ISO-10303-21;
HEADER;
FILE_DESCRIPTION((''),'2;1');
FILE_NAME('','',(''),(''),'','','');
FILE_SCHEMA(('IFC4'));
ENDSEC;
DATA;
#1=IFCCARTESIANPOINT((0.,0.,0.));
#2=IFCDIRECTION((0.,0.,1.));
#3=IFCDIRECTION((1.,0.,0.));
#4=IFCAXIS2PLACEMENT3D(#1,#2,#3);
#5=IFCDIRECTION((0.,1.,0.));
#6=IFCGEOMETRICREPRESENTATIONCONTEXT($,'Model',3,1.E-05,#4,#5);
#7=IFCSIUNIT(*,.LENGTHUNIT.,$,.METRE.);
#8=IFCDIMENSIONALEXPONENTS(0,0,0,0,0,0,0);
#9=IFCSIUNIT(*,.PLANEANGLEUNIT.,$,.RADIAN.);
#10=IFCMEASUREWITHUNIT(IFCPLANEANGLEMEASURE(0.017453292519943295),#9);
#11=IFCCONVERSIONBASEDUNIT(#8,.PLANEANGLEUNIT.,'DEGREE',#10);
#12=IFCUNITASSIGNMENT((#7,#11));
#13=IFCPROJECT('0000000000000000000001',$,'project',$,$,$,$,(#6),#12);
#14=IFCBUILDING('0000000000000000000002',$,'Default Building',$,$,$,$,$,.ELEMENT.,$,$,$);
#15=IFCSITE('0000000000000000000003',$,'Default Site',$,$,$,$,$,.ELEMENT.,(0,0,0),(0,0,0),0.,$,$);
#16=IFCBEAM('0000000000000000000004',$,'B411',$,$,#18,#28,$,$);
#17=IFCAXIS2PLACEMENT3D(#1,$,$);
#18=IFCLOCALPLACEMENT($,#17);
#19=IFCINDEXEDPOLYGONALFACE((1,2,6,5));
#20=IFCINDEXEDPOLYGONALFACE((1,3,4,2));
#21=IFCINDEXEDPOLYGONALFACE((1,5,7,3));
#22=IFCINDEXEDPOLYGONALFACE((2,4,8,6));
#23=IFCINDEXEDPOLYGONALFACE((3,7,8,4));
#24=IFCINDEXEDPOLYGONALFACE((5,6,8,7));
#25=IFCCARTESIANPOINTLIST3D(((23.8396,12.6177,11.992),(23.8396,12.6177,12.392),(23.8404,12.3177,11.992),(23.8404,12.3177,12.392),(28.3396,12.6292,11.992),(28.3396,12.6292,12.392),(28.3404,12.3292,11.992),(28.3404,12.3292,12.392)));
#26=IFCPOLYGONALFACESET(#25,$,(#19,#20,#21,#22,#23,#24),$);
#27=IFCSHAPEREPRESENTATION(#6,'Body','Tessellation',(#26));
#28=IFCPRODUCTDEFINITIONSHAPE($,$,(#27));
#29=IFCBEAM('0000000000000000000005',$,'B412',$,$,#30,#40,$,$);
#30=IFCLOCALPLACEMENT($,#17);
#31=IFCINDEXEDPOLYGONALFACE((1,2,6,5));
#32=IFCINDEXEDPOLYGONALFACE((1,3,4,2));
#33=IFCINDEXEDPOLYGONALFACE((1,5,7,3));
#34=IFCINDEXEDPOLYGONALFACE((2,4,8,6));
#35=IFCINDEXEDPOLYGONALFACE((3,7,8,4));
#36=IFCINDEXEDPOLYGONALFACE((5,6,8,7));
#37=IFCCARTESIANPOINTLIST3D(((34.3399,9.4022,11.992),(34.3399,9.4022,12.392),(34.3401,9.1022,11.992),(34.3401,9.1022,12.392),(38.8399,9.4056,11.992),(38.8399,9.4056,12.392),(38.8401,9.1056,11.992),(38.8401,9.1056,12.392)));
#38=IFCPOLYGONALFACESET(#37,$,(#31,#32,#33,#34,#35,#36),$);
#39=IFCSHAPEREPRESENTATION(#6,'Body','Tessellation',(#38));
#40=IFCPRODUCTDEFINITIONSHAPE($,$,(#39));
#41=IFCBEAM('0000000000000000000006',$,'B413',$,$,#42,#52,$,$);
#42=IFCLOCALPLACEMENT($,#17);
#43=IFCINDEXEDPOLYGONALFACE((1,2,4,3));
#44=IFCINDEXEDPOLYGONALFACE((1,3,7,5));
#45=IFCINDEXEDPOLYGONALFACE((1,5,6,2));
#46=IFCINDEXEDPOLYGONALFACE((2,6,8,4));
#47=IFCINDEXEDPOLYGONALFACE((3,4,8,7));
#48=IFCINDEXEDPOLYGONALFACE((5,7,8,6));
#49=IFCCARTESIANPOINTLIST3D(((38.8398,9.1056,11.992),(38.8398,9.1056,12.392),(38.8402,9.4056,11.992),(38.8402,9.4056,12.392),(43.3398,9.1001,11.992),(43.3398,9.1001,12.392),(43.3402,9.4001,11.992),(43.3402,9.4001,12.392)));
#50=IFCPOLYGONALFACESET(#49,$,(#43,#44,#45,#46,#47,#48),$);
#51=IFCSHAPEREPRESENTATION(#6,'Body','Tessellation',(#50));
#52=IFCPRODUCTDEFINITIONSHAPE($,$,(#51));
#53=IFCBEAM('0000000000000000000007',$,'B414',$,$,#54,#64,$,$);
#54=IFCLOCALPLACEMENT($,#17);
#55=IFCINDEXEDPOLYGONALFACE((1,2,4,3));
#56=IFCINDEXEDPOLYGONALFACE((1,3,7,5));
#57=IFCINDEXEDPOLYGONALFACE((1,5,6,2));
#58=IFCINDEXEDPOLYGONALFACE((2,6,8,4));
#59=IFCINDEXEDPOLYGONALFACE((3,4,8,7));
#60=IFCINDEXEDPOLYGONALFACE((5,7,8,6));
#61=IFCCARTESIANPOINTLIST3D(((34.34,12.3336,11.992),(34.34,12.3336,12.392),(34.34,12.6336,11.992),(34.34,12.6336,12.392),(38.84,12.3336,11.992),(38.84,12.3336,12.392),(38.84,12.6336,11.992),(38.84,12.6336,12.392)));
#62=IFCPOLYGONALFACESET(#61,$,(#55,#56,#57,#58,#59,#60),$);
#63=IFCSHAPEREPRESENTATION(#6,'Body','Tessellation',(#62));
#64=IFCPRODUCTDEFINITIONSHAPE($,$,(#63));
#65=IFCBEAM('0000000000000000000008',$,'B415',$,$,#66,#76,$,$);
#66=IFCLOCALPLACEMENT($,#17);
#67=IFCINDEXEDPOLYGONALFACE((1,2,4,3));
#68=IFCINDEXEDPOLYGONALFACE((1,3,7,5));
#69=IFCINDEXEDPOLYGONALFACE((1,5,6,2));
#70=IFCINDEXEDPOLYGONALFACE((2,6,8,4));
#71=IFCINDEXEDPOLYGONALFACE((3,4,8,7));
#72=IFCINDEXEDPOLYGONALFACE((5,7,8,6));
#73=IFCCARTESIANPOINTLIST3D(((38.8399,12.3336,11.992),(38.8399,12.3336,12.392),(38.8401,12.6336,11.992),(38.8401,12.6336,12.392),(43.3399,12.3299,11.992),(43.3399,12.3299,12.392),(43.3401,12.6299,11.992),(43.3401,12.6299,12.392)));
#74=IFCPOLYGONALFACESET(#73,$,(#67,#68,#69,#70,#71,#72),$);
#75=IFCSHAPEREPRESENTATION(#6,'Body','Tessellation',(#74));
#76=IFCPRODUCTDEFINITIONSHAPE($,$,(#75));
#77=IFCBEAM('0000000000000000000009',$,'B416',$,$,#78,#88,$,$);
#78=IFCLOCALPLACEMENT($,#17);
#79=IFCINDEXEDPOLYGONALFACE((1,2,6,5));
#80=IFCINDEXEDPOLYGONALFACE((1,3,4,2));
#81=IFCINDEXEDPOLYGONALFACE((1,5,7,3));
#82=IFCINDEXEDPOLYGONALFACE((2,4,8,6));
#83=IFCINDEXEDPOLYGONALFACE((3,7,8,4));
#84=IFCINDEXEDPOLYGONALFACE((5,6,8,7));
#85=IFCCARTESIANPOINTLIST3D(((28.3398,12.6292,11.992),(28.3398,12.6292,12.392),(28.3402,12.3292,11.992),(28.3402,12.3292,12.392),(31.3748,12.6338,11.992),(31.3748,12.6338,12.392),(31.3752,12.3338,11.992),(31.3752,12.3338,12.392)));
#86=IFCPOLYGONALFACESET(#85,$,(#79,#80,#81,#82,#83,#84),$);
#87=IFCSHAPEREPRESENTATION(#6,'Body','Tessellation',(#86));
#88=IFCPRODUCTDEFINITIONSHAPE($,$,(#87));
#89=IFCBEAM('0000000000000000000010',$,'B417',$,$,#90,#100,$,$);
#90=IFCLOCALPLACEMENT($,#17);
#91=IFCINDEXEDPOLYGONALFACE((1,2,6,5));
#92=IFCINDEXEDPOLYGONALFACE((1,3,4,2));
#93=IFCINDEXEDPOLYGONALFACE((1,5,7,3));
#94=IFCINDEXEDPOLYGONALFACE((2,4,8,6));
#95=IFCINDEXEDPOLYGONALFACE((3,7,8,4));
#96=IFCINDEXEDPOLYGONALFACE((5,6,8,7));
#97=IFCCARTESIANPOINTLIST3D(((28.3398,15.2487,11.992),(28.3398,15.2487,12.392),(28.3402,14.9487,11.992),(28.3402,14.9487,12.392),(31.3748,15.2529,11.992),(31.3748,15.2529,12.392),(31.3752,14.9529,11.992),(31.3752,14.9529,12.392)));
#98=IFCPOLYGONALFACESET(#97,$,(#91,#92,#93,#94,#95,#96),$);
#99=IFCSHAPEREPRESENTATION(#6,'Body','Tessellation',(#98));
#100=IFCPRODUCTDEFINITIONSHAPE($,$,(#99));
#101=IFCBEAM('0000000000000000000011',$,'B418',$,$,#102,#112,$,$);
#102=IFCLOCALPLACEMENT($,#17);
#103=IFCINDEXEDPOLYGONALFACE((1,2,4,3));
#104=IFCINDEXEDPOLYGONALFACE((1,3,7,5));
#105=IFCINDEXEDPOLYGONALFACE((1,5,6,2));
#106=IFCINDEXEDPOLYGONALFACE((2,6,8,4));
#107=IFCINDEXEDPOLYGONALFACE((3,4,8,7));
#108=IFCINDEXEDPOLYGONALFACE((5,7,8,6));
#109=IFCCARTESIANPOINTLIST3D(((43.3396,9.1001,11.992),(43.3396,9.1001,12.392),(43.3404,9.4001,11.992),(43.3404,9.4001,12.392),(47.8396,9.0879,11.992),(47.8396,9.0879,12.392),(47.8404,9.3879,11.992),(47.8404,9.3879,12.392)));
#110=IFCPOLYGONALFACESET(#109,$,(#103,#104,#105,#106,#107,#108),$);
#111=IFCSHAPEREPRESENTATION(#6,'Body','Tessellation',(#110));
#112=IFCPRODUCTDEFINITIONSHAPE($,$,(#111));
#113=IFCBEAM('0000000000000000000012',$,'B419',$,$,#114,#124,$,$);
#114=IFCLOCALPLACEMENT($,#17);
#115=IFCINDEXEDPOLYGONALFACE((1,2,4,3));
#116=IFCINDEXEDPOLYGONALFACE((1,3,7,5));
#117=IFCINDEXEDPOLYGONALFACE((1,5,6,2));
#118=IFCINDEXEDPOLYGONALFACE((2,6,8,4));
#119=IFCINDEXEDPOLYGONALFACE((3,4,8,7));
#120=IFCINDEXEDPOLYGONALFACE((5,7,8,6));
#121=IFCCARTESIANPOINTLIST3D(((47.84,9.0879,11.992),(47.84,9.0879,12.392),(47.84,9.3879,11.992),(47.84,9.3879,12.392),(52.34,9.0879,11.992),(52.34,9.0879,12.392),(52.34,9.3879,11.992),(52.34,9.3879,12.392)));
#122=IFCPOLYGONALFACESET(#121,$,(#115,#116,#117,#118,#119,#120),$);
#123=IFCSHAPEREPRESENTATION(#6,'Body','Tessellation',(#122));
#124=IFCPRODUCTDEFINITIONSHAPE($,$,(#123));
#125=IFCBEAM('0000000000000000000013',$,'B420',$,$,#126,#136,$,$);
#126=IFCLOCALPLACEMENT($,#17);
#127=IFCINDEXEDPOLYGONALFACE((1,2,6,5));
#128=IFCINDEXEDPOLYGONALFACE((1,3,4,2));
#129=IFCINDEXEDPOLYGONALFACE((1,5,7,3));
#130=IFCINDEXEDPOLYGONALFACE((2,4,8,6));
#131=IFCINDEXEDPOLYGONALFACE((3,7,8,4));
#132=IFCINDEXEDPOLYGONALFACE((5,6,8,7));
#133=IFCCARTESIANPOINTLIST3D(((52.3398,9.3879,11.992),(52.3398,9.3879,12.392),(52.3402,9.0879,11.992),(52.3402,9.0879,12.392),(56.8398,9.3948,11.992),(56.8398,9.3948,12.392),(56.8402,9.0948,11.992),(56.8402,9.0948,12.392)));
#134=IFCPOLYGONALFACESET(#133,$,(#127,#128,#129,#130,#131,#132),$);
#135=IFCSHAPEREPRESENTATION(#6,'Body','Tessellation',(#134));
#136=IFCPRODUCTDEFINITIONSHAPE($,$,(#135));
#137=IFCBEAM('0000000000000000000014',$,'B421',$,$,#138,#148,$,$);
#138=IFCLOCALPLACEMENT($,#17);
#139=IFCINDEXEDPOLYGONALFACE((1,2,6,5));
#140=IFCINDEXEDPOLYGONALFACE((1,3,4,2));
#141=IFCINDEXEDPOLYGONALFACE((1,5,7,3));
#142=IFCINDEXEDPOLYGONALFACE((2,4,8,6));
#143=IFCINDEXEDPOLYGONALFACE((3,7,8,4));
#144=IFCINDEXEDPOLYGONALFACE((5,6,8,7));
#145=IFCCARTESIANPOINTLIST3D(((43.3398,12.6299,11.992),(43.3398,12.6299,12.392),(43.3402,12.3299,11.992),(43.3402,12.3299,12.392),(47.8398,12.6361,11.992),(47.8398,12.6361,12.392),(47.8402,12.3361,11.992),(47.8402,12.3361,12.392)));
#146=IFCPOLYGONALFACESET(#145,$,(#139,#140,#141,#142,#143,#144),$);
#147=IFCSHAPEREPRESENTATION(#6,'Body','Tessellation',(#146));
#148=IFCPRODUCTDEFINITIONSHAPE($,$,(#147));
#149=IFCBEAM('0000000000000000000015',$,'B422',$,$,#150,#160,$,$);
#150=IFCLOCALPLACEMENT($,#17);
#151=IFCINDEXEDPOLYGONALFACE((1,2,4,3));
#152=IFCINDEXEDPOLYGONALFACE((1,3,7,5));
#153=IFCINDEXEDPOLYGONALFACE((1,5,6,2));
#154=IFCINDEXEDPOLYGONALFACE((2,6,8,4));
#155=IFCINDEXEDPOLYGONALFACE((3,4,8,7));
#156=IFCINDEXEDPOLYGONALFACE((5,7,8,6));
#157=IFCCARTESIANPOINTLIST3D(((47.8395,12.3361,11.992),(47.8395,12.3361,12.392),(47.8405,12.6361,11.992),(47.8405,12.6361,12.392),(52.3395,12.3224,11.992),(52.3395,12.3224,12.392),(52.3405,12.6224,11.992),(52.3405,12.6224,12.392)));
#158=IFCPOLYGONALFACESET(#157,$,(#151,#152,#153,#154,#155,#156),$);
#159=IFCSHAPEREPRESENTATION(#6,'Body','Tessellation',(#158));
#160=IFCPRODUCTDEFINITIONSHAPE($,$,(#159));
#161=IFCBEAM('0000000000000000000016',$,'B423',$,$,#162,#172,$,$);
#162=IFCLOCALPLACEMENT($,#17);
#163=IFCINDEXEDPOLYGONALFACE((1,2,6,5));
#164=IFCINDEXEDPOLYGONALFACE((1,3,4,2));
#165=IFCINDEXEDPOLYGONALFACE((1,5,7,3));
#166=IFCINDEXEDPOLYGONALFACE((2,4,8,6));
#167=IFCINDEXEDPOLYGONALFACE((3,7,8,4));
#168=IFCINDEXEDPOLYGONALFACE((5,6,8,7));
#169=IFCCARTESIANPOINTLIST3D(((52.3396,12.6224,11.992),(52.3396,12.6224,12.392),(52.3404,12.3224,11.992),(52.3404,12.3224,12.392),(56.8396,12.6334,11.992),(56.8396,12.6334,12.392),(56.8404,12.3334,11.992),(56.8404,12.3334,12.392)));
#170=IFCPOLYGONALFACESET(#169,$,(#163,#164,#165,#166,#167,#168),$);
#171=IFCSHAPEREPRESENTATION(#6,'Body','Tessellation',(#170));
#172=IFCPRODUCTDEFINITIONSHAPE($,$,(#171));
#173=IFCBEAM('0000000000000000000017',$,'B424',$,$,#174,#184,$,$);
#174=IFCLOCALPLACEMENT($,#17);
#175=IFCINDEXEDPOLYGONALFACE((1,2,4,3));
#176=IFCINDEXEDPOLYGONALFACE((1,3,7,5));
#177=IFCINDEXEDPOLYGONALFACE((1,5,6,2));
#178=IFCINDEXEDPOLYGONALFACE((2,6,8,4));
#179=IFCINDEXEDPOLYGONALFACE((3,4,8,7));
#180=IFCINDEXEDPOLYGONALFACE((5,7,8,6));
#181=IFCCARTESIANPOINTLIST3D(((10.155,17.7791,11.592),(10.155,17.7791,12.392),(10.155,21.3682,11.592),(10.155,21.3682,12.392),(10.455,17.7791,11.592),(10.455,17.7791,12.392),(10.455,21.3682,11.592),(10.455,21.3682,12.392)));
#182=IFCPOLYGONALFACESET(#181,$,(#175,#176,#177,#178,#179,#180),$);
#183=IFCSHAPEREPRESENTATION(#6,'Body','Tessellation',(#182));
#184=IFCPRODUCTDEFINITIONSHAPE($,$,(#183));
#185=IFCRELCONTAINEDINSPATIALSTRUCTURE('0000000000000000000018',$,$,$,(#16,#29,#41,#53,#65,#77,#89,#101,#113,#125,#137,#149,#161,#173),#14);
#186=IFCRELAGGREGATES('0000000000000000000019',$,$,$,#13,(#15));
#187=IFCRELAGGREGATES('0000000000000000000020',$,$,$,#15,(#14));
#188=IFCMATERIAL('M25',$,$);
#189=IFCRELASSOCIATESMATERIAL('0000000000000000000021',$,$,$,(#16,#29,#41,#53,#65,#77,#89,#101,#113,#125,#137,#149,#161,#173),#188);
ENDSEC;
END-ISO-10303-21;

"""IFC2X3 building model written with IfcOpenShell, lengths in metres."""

from ifc_helpers import new_model, entity, si_unit, converted_unit, direction, frame, frame_2d, origin_with_axes, place, context, project, spatial, rectangle, extrude, material, element, save


model = new_model("IFC2X3")

# Units and contexts
model_context = context("Model", 3, precision=1e-05, world=origin_with_axes(), true_north=direction((0.0, 1.0, 0.0)))
ifc_project = project(units=[si_unit("LENGTHUNIT", "METRE"), converted_unit("PLANEANGLEUNIT", "DEGREE", entity("IfcPlaneAngleMeasure", 0.017453292519943295), si_unit("PLANEANGLEUNIT", "RADIAN"), dimensions=[0, 0, 0, 0, 0, 0, 0])], contexts=[model_context])

# Site, building
site = spatial("IfcSite", under=ifc_project, Name="Default Site", CompositionType="ELEMENT", RefLatitude=(0, 0, 0), RefLongitude=(0, 0, 0), RefElevation=0.0)
building = spatial("IfcBuilding", under=site, Name="Default Building", CompositionType="ELEMENT")

# Beams
ifc_material = material(Name="M25")
placement = place(None, origin_with_axes())
element("IfcBeam", 1, at=placement, inside=building, material=ifc_material, Name="B411", context=model_context, shape_type="SweptSolid", body=[
    extrude(rectangle(XDim=0.3, YDim=0.4, at=frame_2d((0.0, 0.0), x_axis=(0.0, 1.0, 0.0))), frame((23.84, 12.4677, 12.192), z_axis=(0.999997, 0.002551, 0.0), x_axis=(0.0, 0.0, -1.0)), (0.0, 0.0, 1.0), 4.5),
])
element("IfcBeam", 2, at=placement, inside=building, material=ifc_material, Name="B412", context=model_context, shape_type="SweptSolid", body=[
    extrude(rectangle(XDim=0.3, YDim=0.4, at=frame_2d((0.0, 0.0), x_axis=(0.0, 1.0, 0.0))), frame((34.34, 9.2522, 12.192), z_axis=(1.0, 0.000748, 0.0), x_axis=(0.0, 0.0, -1.0)), (0.0, 0.0, 1.0), 4.5),
])
element("IfcBeam", 3, at=placement, inside=building, material=ifc_material, Name="B413", context=model_context, shape_type="SweptSolid", body=[
    extrude(rectangle(XDim=0.3, YDim=0.4, at=frame_2d((0.0, 0.0), x_axis=(0.0, 1.0, 0.0))), frame((38.84, 9.2556, 12.192), z_axis=(0.999999, -0.001227, 0.0), x_axis=(0.0, 0.0, -1.0)), (0.0, 0.0, 1.0), 4.5),
])
element("IfcBeam", 4, at=placement, inside=building, material=ifc_material, Name="B414", context=model_context, shape_type="SweptSolid", body=[
    extrude(rectangle(XDim=0.3, YDim=0.4, at=frame_2d((0.0, 0.0), x_axis=(0.0, 1.0, 0.0))), frame((34.34, 12.4836, 12.192), z_axis=(1.0, -0.000008, 0.0), x_axis=(0.0, 0.0, -1.0)), (0.0, 0.0, 1.0), 4.5),
])
element("IfcBeam", 5, at=placement, inside=building, material=ifc_material, Name="B415", context=model_context, shape_type="SweptSolid", body=[
    extrude(rectangle(XDim=0.3, YDim=0.4, at=frame_2d((0.0, 0.0), x_axis=(0.0, 1.0, 0.0))), frame((38.84, 12.4836, 12.192), z_axis=(1.0, -0.000826, 0.0), x_axis=(0.0, 0.0, -1.0)), (0.0, 0.0, 1.0), 4.5),
])
element("IfcBeam", 6, at=placement, inside=building, material=ifc_material, Name="B416", context=model_context, shape_type="SweptSolid", body=[
    extrude(rectangle(XDim=0.3, YDim=0.4, at=frame_2d((0.0, 0.0), x_axis=(0.0, 1.0, 0.0))), frame((28.34, 12.4792, 12.192), z_axis=(0.999999, 0.001542, 0.0), x_axis=(0.0, 0.0, -1.0)), (0.0, 0.0, 1.0), 3.035),
])
element("IfcBeam", 7, at=placement, inside=building, material=ifc_material, Name="B417", context=model_context, shape_type="SweptSolid", body=[
    extrude(rectangle(XDim=0.3, YDim=0.4, at=frame_2d((0.0, 0.0), x_axis=(0.0, 1.0, 0.0))), frame((31.375, 15.1029, 12.192), z_axis=(-0.999999, -0.001391, 0.0), x_axis=(0.0, 0.0, -1.0)), (0.0, 0.0, 1.0), 3.035),
])
element("IfcBeam", 8, at=placement, inside=building, material=ifc_material, Name="B418", context=model_context, shape_type="SweptSolid", body=[
    extrude(rectangle(XDim=0.3, YDim=0.4, at=frame_2d((0.0, 0.0), x_axis=(0.0, 1.0, 0.0))), frame((43.34, 9.2501, 12.192), z_axis=(0.999996, -0.002702, 0.0), x_axis=(0.0, 0.0, -1.0)), (0.0, 0.0, 1.0), 4.5),
])
element("IfcBeam", 9, at=placement, inside=building, material=ifc_material, Name="B419", context=model_context, shape_type="SweptSolid", body=[
    extrude(rectangle(XDim=0.3, YDim=0.4, at=frame_2d((0.0, 0.0), x_axis=(0.0, 1.0, 0.0))), frame((47.84, 9.2379, 12.192), z_axis=(1.0, 0.0, 0.0), x_axis=(0.0, 0.0, -1.0)), (0.0, 0.0, 1.0), 4.5),
])
element("IfcBeam", 10, at=placement, inside=building, material=ifc_material, Name="B420", context=model_context, shape_type="SweptSolid", body=[
    extrude(rectangle(XDim=0.3, YDim=0.4, at=frame_2d((0.0, 0.0), x_axis=(0.0, 1.0, 0.0))), frame((52.34, 9.2379, 12.192), z_axis=(0.999999, 0.001537, 0.0), x_axis=(0.0, 0.0, -1.0)), (0.0, 0.0, 1.0), 4.5),
])
element("IfcBeam", 11, at=placement, inside=building, material=ifc_material, Name="B421", context=model_context, shape_type="SweptSolid", body=[
    extrude(rectangle(XDim=0.3, YDim=0.4, at=frame_2d((0.0, 0.0), x_axis=(0.0, 1.0, 0.0))), frame((43.34, 12.4799, 12.192), z_axis=(0.999999, 0.001374, 0.0), x_axis=(0.0, 0.0, -1.0)), (0.0, 0.0, 1.0), 4.5),
])
element("IfcBeam", 12, at=placement, inside=building, material=ifc_material, Name="B422", context=model_context, shape_type="SweptSolid", body=[
    extrude(rectangle(XDim=0.3, YDim=0.4, at=frame_2d((0.0, 0.0), x_axis=(0.0, 1.0, 0.0))), frame((47.84, 12.4861, 12.192), z_axis=(0.999995, -0.003045, 0.0), x_axis=(0.0, 0.0, -1.0)), (0.0, 0.0, 1.0), 4.5),
])
element("IfcBeam", 13, at=placement, inside=building, material=ifc_material, Name="B423", context=model_context, shape_type="SweptSolid", body=[
    extrude(rectangle(XDim=0.3, YDim=0.4, at=frame_2d((0.0, 0.0), x_axis=(0.0, 1.0, 0.0))), frame((52.34, 12.4724, 12.192), z_axis=(0.999997, 0.002456, 0.0), x_axis=(0.0, 0.0, -1.0)), (0.0, 0.0, 1.0), 4.5),
])
element("IfcBeam", 14, at=placement, inside=building, material=ifc_material, Name="B424", context=model_context, shape_type="SweptSolid", body=[
    extrude(rectangle(XDim=0.3, YDim=0.8, at=frame_2d((0.0, 0.0), x_axis=(0.0, 1.0, 0.0))), frame((10.305, 21.3682, 11.992), z_axis=(0.0, -1.0, 0.0), x_axis=(0.0, 0.0, -1.0)), (0.0, 0.0, 1.0), 3.5891),
])

save(model, "model.ifc")
